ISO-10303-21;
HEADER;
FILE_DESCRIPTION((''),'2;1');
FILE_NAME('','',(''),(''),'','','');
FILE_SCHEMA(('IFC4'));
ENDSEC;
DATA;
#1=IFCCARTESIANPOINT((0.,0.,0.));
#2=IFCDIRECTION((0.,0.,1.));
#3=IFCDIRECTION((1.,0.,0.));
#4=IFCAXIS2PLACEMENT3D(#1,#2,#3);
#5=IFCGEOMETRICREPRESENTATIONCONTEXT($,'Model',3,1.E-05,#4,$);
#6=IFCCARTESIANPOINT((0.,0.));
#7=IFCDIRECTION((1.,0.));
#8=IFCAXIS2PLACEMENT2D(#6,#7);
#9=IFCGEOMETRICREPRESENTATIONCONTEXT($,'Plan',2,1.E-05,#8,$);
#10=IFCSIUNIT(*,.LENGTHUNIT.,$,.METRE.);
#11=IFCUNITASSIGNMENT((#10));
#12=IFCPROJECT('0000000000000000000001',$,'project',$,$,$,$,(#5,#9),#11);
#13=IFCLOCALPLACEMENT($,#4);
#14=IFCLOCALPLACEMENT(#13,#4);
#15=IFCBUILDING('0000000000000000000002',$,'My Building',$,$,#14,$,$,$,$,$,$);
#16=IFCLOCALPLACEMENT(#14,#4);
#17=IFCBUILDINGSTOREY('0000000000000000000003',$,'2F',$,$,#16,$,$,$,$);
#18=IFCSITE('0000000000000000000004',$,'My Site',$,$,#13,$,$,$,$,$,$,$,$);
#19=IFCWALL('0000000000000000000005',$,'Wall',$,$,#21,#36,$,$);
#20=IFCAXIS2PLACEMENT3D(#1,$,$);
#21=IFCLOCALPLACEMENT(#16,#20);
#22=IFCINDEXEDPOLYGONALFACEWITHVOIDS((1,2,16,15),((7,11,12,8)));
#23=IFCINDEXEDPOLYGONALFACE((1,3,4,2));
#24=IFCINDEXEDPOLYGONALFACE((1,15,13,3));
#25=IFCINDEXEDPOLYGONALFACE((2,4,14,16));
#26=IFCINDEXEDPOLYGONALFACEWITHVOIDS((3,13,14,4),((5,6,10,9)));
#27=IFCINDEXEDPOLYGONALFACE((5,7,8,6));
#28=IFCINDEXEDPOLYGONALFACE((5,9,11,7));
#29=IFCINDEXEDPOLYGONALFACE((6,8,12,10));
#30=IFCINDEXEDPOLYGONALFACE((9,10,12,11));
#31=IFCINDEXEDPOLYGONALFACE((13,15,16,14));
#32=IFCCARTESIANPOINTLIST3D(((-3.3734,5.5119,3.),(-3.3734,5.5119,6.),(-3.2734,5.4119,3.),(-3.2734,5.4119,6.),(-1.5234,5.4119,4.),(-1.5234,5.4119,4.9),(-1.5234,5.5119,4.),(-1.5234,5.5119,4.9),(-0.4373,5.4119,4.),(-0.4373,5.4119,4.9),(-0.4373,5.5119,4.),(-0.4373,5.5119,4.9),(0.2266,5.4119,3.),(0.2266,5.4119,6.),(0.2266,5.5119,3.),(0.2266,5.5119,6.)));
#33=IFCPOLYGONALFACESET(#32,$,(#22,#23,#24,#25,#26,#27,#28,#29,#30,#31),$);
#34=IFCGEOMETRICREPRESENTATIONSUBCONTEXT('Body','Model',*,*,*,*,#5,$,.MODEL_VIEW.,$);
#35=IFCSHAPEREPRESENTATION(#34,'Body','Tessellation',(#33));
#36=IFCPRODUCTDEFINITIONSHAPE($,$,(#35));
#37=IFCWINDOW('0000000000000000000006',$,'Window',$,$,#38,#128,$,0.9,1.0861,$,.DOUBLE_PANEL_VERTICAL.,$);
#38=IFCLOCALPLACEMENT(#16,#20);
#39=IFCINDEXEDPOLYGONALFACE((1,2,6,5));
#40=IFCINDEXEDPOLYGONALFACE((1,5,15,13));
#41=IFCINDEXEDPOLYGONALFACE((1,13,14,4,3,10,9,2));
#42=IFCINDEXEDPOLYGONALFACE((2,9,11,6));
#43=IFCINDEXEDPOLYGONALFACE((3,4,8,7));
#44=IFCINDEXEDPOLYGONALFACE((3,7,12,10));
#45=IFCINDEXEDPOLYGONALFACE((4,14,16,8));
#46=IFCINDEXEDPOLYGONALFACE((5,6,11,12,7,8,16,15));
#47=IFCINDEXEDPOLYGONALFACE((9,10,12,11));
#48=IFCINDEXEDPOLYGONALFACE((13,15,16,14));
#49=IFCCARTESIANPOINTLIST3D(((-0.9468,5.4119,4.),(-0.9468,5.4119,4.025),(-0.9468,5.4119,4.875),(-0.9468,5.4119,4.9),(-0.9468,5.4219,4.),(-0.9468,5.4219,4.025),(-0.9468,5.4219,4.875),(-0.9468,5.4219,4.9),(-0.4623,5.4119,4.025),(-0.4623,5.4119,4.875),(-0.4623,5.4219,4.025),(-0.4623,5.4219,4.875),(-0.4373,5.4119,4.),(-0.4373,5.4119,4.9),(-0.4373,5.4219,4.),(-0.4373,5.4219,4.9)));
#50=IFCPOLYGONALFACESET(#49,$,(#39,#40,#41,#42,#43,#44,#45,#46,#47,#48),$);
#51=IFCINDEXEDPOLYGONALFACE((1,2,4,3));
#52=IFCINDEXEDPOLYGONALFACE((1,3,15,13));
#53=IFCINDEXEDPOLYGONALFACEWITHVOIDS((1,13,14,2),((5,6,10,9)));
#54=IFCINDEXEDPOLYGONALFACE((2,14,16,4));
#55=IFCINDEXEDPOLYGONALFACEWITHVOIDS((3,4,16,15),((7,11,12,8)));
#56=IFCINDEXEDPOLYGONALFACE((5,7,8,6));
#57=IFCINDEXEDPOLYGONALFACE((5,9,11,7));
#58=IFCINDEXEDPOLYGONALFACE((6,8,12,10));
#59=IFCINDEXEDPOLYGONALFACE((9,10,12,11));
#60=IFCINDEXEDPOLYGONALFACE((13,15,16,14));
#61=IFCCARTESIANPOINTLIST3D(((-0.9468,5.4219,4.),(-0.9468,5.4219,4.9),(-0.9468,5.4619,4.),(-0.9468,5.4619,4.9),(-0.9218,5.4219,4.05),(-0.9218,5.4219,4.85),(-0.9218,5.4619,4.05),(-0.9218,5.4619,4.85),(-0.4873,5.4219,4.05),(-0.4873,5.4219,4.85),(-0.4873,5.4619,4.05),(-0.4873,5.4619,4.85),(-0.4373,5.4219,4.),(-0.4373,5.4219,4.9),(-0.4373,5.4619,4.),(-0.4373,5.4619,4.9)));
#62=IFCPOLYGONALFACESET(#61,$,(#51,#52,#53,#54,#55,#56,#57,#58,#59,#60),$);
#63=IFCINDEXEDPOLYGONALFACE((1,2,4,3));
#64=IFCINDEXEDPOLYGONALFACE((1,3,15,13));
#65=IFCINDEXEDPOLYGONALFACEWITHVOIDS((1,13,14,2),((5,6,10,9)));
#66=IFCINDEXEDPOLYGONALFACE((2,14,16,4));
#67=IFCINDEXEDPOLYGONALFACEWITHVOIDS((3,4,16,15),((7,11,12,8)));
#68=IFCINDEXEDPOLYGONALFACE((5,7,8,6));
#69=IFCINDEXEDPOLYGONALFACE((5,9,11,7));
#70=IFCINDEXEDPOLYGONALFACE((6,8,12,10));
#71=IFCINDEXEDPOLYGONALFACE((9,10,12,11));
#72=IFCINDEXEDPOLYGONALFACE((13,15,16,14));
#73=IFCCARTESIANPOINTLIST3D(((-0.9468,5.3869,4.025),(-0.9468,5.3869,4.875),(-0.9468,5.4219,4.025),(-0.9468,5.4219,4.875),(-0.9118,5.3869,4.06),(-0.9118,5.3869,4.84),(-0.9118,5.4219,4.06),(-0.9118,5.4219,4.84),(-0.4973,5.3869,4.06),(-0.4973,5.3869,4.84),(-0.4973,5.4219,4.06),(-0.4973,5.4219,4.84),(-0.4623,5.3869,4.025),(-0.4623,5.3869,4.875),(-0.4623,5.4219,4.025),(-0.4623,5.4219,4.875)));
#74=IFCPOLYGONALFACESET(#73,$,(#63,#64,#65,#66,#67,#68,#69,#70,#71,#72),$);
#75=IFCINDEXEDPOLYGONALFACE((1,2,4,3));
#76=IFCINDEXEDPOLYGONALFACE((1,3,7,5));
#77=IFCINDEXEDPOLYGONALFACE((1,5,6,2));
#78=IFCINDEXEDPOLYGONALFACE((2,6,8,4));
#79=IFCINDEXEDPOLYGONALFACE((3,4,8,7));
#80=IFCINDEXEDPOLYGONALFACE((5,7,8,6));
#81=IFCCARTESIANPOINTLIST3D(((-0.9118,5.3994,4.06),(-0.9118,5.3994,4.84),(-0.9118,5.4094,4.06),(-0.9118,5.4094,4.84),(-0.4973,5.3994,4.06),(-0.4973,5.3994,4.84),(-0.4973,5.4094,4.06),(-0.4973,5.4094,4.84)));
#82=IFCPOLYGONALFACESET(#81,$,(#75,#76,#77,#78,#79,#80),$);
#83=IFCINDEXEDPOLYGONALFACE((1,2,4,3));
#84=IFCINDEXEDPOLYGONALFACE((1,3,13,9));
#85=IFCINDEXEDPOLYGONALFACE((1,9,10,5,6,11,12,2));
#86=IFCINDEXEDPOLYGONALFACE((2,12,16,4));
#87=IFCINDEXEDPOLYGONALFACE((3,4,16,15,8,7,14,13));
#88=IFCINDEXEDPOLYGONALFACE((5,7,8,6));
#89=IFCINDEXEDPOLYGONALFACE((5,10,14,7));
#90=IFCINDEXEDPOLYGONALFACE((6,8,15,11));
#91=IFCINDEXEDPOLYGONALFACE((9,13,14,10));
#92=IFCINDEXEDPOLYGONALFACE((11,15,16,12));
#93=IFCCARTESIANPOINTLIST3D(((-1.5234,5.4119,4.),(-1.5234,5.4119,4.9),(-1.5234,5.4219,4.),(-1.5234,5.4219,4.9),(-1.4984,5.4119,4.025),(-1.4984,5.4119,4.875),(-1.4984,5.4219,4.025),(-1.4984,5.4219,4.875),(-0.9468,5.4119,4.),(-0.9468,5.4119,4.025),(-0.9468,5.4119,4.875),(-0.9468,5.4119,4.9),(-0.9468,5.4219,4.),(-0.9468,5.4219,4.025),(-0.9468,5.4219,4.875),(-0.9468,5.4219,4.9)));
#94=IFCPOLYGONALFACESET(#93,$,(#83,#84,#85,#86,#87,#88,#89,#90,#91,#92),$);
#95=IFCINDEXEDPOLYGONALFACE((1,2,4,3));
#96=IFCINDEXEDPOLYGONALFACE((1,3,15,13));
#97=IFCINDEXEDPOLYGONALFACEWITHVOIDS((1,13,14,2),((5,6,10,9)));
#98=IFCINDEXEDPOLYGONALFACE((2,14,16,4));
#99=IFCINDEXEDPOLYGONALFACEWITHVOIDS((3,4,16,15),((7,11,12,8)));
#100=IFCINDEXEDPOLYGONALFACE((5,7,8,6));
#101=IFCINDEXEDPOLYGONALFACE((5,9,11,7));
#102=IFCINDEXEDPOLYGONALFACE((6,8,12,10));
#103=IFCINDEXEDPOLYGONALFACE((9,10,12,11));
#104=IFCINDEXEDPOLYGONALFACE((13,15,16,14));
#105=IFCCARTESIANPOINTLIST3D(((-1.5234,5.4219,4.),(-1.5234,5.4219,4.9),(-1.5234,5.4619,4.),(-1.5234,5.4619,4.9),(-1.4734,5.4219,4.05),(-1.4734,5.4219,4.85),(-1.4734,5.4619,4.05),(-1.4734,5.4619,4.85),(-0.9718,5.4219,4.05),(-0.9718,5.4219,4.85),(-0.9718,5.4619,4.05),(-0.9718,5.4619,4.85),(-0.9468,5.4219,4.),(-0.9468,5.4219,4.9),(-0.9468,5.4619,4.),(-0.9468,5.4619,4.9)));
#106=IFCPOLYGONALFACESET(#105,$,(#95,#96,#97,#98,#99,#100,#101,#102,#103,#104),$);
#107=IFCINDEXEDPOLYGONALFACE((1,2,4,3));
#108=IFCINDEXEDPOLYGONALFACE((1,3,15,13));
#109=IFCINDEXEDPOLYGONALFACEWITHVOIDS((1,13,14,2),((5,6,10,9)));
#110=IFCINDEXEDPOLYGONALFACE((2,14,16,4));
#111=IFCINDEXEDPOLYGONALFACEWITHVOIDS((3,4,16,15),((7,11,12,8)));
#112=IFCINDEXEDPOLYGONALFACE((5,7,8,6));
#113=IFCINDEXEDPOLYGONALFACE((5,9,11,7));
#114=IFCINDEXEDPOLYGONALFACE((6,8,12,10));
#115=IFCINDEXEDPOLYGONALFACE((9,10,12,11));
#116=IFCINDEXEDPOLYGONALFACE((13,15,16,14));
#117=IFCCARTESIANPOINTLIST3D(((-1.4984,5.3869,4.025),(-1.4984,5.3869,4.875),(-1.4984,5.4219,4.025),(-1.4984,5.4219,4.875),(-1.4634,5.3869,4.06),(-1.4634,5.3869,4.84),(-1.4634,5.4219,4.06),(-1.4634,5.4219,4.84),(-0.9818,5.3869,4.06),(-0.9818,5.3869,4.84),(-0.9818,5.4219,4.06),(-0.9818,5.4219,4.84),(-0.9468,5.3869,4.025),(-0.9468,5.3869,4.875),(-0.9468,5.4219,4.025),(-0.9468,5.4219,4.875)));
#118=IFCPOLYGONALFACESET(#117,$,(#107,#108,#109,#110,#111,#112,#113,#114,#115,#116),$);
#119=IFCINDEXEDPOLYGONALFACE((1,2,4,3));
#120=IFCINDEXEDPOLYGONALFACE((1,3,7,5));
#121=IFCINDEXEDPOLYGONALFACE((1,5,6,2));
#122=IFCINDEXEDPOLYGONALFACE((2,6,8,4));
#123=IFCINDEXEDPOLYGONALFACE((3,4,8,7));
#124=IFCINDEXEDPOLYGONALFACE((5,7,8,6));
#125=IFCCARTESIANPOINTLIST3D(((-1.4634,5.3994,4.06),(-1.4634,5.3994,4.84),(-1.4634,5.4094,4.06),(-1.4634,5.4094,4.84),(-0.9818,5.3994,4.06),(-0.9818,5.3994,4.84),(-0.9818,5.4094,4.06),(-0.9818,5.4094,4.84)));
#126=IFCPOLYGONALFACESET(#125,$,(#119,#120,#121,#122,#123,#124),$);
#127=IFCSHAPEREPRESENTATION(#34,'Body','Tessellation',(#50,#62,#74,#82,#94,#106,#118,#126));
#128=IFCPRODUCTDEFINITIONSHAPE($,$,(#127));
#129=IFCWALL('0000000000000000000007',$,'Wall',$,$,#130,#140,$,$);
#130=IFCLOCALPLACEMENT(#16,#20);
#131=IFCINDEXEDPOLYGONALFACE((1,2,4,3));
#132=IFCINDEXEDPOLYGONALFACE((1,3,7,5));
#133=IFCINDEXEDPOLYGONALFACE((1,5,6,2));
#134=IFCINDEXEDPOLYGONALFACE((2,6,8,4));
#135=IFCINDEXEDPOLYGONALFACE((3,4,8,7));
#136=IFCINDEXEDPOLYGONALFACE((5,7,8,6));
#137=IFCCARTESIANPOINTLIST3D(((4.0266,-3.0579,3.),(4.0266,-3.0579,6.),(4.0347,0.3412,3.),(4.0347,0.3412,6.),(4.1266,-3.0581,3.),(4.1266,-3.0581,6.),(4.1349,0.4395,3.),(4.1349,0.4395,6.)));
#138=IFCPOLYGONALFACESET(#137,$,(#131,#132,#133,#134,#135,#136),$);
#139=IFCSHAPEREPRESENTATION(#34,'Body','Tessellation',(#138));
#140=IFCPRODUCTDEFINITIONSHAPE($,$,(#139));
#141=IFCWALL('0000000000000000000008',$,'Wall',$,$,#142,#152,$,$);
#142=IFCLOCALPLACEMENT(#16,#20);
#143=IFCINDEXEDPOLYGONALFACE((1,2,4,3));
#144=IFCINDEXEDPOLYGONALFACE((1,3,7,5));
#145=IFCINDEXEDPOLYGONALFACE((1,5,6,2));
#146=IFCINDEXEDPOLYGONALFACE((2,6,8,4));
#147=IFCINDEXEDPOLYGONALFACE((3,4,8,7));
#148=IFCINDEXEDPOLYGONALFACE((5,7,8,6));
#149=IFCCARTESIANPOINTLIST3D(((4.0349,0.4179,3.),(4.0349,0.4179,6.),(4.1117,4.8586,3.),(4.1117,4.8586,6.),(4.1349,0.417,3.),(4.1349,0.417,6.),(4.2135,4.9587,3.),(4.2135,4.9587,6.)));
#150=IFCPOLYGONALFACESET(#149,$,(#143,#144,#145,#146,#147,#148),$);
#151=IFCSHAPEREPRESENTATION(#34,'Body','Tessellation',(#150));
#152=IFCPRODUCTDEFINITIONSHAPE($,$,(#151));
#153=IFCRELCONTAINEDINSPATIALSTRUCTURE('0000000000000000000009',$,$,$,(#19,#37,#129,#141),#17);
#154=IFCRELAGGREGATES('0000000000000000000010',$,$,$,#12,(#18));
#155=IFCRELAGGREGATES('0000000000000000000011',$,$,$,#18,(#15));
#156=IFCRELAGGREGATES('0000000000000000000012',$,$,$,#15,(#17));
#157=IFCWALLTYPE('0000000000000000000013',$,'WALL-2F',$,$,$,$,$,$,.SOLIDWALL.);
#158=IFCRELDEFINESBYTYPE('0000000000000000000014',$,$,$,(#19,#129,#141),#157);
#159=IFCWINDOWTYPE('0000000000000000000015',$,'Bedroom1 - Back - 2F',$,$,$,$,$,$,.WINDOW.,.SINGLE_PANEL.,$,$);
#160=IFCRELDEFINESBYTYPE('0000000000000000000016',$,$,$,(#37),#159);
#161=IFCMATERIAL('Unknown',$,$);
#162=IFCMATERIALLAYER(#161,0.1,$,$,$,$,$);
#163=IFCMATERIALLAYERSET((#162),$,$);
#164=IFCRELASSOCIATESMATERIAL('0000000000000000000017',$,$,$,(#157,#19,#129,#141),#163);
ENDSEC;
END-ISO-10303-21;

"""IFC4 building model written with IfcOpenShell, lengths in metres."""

from ifc_helpers import new_model, entity, si_unit, frame, origin_with_axes, origin_2d_with_axis, place, context, subcontext, project, spatial, line, indexed_curve, outline, extrude, shape, source, transform, mapped, material, layer, layer_set, layer_usage, type_object, type_shapes, element, fill, save


model = new_model("IFC4")

# Units and contexts
model_context = context("Model", 3, precision=1e-05, world=origin_with_axes())
plan_context = context("Plan", 2, precision=1e-05, world=origin_2d_with_axis())
body_context_1 = subcontext(model_context, "Body", "Model", "MODEL_VIEW")
body_context_2 = subcontext(plan_context, "Body", "Plan", "PLAN_VIEW")
ifc_project = project(units=[si_unit("LENGTHUNIT", "METRE")], contexts=[model_context, plan_context])

# Site, building, storey
site_placement = place(None, origin_with_axes())
site = spatial("IfcSite", under=ifc_project, at=site_placement, Name="My Site")
building_placement = place(site_placement, origin_with_axes())
building = spatial("IfcBuilding", under=site, at=building_placement, Name="My Building")
storey_placement = place(building_placement, origin_with_axes())
storey = spatial("IfcBuildingStorey", under=building, at=storey_placement, Name="2F")

# Shared definitions
ifc_material = material(Name="Unknown")

# Shared definitions
ifc_layer_1 = layer(ifc_material, 0.1)
ifc_layer_set_1 = layer_set([ifc_layer_1])
wall_type_1 = type_object("IfcWallType", Name="WALL-2F", PredefinedType="SOLIDWALL", material=ifc_layer_set_1)

# Wall, opening, window
ifc_layer_usage_1 = layer_usage(ifc_layer_set_1, "AXIS2", "POSITIVE", 0.0)
wall_1_placement = place(storey_placement, frame((0.2266, 5.5119, 3.0), z_axis=(0.0, 0.0, 1.0), x_axis=(-1.0, 0.0, 0.0)))
wall_1 = element("IfcWall", 1, at=wall_1_placement, inside=storey, type_object=wall_type_1, material=ifc_layer_usage_1, Name="Wall", context=body_context_1, shape_type="SweptSolid", body=[
    extrude(outline(indexed_curve([(0.0, 0.0), (0.0, 0.1), (3.5, 0.1), (3.6, 0.0)], segments=[line(1, 2, 3, 4, 1)])), origin_with_axes(), (0.0, 0.0, 1.0), 3.0),
])
shared_shape_1 = source(origin_with_axes(), body_context_1, "Body", "SweptSolid", [
    extrude(outline(indexed_curve([(0.0, 0.0), (1.0861, 0.0), (1.0861, 0.9), (0.0, 0.9)], segments=[line(1, 2, 3, 4, 1)])), frame((0.0, -0.6, 0.0), z_axis=(0.0, -1.0, 0.0), x_axis=(1.0, 0.0, 0.0)), (0.0, 0.0, -1.0), 1.2),
])
opening_1_placement = place(wall_1_placement, frame((0.6639, 0.0, 1.0), z_axis=(0.0, 0.0, 1.0), x_axis=(1.0, 0.0, 0.0)))
opening_1 = element("IfcOpeningElement", 2, at=opening_1_placement, cuts=wall_1, PredefinedType="OPENING", context=body_context_1, shape_type="MappedRepresentation", body=[
    mapped(shared_shape_1, transform((0.0, 0.0, 0.0), x_axis=(1.0, 0.0, 0.0), y_axis=(0.0, 1.0, 0.0), z_axis=(0.0, 0.0, 1.0), scale=1.0)),
])
window_type_1 = type_object("IfcWindowType", Name="Bedroom1 - Back - 2F", PartitioningType="SINGLE_PANEL", PredefinedType="WINDOW")
shared_shape_2 = source(origin_with_axes(), body_context_1, "Body", "SweptSolid", [
    extrude(outline(indexed_curve([(0.5096, 0.0), (0.0, 0.0), (0.0, 0.9), (0.5096, 0.9), (0.5096, 0.875), (0.025, 0.875), (0.025, 0.025), (0.5096, 0.025)], segments=[line(1, 2, 3, 4, 5, 6, 7, 8, 1)])), frame((0.0, 0.09, 0.0), z_axis=(0.0, -1.0, 0.0), x_axis=(1.0, 0.0, 0.0)), (0.0, 0.0, -1.0), 0.01),
    extrude(outline(indexed_curve([(0.0, 0.0), (0.5096, 0.0), (0.5096, 0.9), (0.0, 0.9)], segments=[line(1, 2, 3, 4, 1)]), holes=[indexed_curve([(0.05, 0.05), (0.4846, 0.05), (0.4846, 0.85), (0.05, 0.85)], segments=[line(1, 2, 3, 4, 1)])]), frame((0.0, 0.05, 0.0), z_axis=(0.0, -1.0, 0.0), x_axis=(1.0, 0.0, 0.0)), (0.0, 0.0, -1.0), 0.04),
    extrude(outline(indexed_curve([(0.0, 0.0), (0.4846, 0.0), (0.4846, 0.85), (0.0, 0.85)], segments=[line(1, 2, 3, 4, 1)]), holes=[indexed_curve([(0.035, 0.035), (0.4496, 0.035), (0.4496, 0.815), (0.035, 0.815)], segments=[line(1, 2, 3, 4, 1)])]), frame((0.025, 0.09, 0.025), z_axis=(0.0, -1.0, 0.0), x_axis=(1.0, 0.0, 0.0)), (0.0, 0.0, -1.0), 0.035),
    extrude(outline(indexed_curve([(0.035, 0.035), (0.4496, 0.035), (0.4496, 0.815), (0.035, 0.815)], segments=[line(1, 2, 3, 4, 1)])), frame((0.025, 0.1025, 0.025), z_axis=(0.0, -1.0, 0.0), x_axis=(1.0, 0.0, 0.0)), (0.0, 0.0, -1.0), 0.01),
    extrude(outline(indexed_curve([(0.0, 0.9), (0.5766, 0.9), (0.5766, 0.0), (0.0, 0.0), (0.0, 0.025), (0.5516, 0.025), (0.5516, 0.875), (0.0, 0.875)], segments=[line(1, 2, 3, 4, 5, 6, 7, 8, 1)])), frame((0.5096, 0.09, 0.0), z_axis=(0.0, -1.0, 0.0), x_axis=(1.0, 0.0, 0.0)), (0.0, 0.0, -1.0), 0.01),
    extrude(outline(indexed_curve([(0.0, 0.0), (0.5766, 0.0), (0.5766, 0.9), (0.0, 0.9)], segments=[line(1, 2, 3, 4, 1)]), holes=[indexed_curve([(0.025, 0.05), (0.5266, 0.05), (0.5266, 0.85), (0.025, 0.85)], segments=[line(1, 2, 3, 4, 1)])]), frame((0.5096, 0.05, 0.0), z_axis=(0.0, -1.0, 0.0), x_axis=(1.0, 0.0, 0.0)), (0.0, 0.0, -1.0), 0.04),
    extrude(outline(indexed_curve([(0.0, 0.0), (0.5516, 0.0), (0.5516, 0.85), (0.0, 0.85)], segments=[line(1, 2, 3, 4, 1)]), holes=[indexed_curve([(0.035, 0.035), (0.5166, 0.035), (0.5166, 0.815), (0.035, 0.815)], segments=[line(1, 2, 3, 4, 1)])]), frame((0.5096, 0.09, 0.025), z_axis=(0.0, -1.0, 0.0), x_axis=(1.0, 0.0, 0.0)), (0.0, 0.0, -1.0), 0.035),
    extrude(outline(indexed_curve([(0.035, 0.035), (0.5166, 0.035), (0.5166, 0.815), (0.035, 0.815)], segments=[line(1, 2, 3, 4, 1)])), frame((0.5096, 0.1025, 0.025), z_axis=(0.0, -1.0, 0.0), x_axis=(1.0, 0.0, 0.0)), (0.0, 0.0, -1.0), 0.01),
])
shared_shape_3 = source(origin_with_axes(), body_context_2, "Body", "Curve2D", [
    entity("IfcIndexedPolyCurve", entity("IfcCartesianPointList2D", [[0.05, 0.05], [0.4846, 0.05]])),
    entity("IfcIndexedPolyCurve", entity("IfcCartesianPointList2D", [[0.0, 0.1], [0.025, 0.1], [0.025, 0.09], [0.05, 0.09], [0.05, 0.05], [0.0, 0.05]]), [entity("IfcLineIndex", [1, 2, 3, 4, 5, 6, 1])]),
    entity("IfcIndexedPolyCurve", entity("IfcCartesianPointList2D", [[0.5096, 0.1], [0.5096, 0.1], [0.5096, 0.09], [0.4846, 0.09], [0.4846, 0.05], [0.5096, 0.05]])),
    entity("IfcIndexedPolyCurve", entity("IfcCartesianPointList2D", [[0.025, 0.09], [0.06, 0.09], [0.06, 0.125], [0.025, 0.125]]), [entity("IfcLineIndex", [1, 2, 3, 4, 1])]),
    entity("IfcIndexedPolyCurve", entity("IfcCartesianPointList2D", [[0.5096, 0.09], [0.4746, 0.09], [0.4746, 0.125], [0.5096, 0.125]]), [entity("IfcLineIndex", [1, 2, 3, 4, 1])]),
    entity("IfcIndexedPolyCurve", entity("IfcCartesianPointList2D", [[0.06, 0.09], [0.4746, 0.09]])),
    entity("IfcIndexedPolyCurve", entity("IfcCartesianPointList2D", [[0.06, 0.125], [0.4746, 0.125]])),
    entity("IfcIndexedPolyCurve", entity("IfcCartesianPointList2D", [[0.06, 0.1075], [0.4746, 0.1075]])),
    entity("IfcIndexedPolyCurve", entity("IfcCartesianPointList2D", [[0.5346, 0.05], [1.0361, 0.05]])),
    entity("IfcIndexedPolyCurve", entity("IfcCartesianPointList2D", [[0.5096, 0.1], [0.5096, 0.1], [0.5096, 0.09], [0.5346, 0.09], [0.5346, 0.05], [0.5096, 0.05]])),
    entity("IfcIndexedPolyCurve", entity("IfcCartesianPointList2D", [[1.0861, 0.1], [1.0611, 0.1], [1.0611, 0.09], [1.0361, 0.09], [1.0361, 0.05], [1.0861, 0.05]]), [entity("IfcLineIndex", [1, 2, 3, 4, 5, 6, 1])]),
    entity("IfcIndexedPolyCurve", entity("IfcCartesianPointList2D", [[0.5096, 0.09], [0.5446, 0.09], [0.5446, 0.125], [0.5096, 0.125]]), [entity("IfcLineIndex", [1, 2, 3, 4, 1])]),
    entity("IfcIndexedPolyCurve", entity("IfcCartesianPointList2D", [[1.0611, 0.09], [1.0261, 0.09], [1.0261, 0.125], [1.0611, 0.125]]), [entity("IfcLineIndex", [1, 2, 3, 4, 1])]),
    entity("IfcIndexedPolyCurve", entity("IfcCartesianPointList2D", [[0.5446, 0.09], [1.0261, 0.09]])),
    entity("IfcIndexedPolyCurve", entity("IfcCartesianPointList2D", [[0.5446, 0.125], [1.0261, 0.125]])),
    entity("IfcIndexedPolyCurve", entity("IfcCartesianPointList2D", [[0.5446, 0.1075], [1.0261, 0.1075]])),
])
type_shapes(window_type_1, [shared_shape_2, shared_shape_3])
window_1_placement = place(opening_1_placement, frame((0.0, 0.0, 0.0), z_axis=(0.0, 0.0, 1.0), x_axis=(1.0, 0.0, 0.0)))
window_1 = element("IfcWindow", 3, at=window_1_placement, inside=storey, type_object=window_type_1, Name="Window", OverallHeight=0.9, OverallWidth=1.0861, PartitioningType="DOUBLE_PANEL_VERTICAL", shapes=[
    shape(body_context_1, "Body", "MappedRepresentation", [mapped(shared_shape_2, transform((0.0, 0.0, 0.0), x_axis=(1.0, 0.0, 0.0), y_axis=(0.0, 1.0, 0.0), z_axis=(0.0, 0.0, 1.0), scale=1.0))]),
    shape(body_context_2, "Body", "MappedRepresentation", [mapped(shared_shape_3, transform((0.0, 0.0, 0.0), x_axis=(1.0, 0.0, 0.0), y_axis=(0.0, 1.0, 0.0), z_axis=(0.0, 0.0, 1.0), scale=1.0))]),
])
fill(opening_1, window_1)

# Walls
ifc_layer_usage_2 = layer_usage(ifc_layer_set_1, "AXIS2", "POSITIVE", 0.0)
wall_2_placement = place(storey_placement, frame((4.1266, -3.0581, 3.0), z_axis=(0.0, 0.0, 1.0), x_axis=(0.002384, 0.999997, 0.0)))
element("IfcWall", 4, at=wall_2_placement, inside=storey, type_object=wall_type_1, material=ifc_layer_usage_2, Name="Wall", context=body_context_1, shape_type="SweptSolid", body=[
    extrude(outline(indexed_curve([(0.0, 0.0), (0.0, 0.1), (3.3991, 0.1), (3.4976, 0.0)], segments=[line(1, 2, 3, 4, 1)])), origin_with_axes(), (0.0, 0.0, 1.0), 3.0),
])
ifc_layer_usage_3 = layer_usage(ifc_layer_set_1, "AXIS2", "POSITIVE", 0.0)
wall_3_placement = place(storey_placement, frame((4.1349, 0.417, 3.0), z_axis=(0.0, 0.0, 1.0), x_axis=(0.017301, 0.99985, 0.0)))
element("IfcWall", 5, at=wall_3_placement, inside=storey, type_object=wall_type_1, material=ifc_layer_usage_3, Name="Wall", context=body_context_1, shape_type="SweptSolid", body=[
    extrude(outline(indexed_curve([(0.0, 0.0), (-0.0007, 0.1), (4.4406, 0.1), (4.5424, 0.0)], segments=[line(1, 2, 3, 4, 1)])), origin_with_axes(), (0.0, 0.0, 1.0), 3.0),
])

save(model, "model.ifc")
